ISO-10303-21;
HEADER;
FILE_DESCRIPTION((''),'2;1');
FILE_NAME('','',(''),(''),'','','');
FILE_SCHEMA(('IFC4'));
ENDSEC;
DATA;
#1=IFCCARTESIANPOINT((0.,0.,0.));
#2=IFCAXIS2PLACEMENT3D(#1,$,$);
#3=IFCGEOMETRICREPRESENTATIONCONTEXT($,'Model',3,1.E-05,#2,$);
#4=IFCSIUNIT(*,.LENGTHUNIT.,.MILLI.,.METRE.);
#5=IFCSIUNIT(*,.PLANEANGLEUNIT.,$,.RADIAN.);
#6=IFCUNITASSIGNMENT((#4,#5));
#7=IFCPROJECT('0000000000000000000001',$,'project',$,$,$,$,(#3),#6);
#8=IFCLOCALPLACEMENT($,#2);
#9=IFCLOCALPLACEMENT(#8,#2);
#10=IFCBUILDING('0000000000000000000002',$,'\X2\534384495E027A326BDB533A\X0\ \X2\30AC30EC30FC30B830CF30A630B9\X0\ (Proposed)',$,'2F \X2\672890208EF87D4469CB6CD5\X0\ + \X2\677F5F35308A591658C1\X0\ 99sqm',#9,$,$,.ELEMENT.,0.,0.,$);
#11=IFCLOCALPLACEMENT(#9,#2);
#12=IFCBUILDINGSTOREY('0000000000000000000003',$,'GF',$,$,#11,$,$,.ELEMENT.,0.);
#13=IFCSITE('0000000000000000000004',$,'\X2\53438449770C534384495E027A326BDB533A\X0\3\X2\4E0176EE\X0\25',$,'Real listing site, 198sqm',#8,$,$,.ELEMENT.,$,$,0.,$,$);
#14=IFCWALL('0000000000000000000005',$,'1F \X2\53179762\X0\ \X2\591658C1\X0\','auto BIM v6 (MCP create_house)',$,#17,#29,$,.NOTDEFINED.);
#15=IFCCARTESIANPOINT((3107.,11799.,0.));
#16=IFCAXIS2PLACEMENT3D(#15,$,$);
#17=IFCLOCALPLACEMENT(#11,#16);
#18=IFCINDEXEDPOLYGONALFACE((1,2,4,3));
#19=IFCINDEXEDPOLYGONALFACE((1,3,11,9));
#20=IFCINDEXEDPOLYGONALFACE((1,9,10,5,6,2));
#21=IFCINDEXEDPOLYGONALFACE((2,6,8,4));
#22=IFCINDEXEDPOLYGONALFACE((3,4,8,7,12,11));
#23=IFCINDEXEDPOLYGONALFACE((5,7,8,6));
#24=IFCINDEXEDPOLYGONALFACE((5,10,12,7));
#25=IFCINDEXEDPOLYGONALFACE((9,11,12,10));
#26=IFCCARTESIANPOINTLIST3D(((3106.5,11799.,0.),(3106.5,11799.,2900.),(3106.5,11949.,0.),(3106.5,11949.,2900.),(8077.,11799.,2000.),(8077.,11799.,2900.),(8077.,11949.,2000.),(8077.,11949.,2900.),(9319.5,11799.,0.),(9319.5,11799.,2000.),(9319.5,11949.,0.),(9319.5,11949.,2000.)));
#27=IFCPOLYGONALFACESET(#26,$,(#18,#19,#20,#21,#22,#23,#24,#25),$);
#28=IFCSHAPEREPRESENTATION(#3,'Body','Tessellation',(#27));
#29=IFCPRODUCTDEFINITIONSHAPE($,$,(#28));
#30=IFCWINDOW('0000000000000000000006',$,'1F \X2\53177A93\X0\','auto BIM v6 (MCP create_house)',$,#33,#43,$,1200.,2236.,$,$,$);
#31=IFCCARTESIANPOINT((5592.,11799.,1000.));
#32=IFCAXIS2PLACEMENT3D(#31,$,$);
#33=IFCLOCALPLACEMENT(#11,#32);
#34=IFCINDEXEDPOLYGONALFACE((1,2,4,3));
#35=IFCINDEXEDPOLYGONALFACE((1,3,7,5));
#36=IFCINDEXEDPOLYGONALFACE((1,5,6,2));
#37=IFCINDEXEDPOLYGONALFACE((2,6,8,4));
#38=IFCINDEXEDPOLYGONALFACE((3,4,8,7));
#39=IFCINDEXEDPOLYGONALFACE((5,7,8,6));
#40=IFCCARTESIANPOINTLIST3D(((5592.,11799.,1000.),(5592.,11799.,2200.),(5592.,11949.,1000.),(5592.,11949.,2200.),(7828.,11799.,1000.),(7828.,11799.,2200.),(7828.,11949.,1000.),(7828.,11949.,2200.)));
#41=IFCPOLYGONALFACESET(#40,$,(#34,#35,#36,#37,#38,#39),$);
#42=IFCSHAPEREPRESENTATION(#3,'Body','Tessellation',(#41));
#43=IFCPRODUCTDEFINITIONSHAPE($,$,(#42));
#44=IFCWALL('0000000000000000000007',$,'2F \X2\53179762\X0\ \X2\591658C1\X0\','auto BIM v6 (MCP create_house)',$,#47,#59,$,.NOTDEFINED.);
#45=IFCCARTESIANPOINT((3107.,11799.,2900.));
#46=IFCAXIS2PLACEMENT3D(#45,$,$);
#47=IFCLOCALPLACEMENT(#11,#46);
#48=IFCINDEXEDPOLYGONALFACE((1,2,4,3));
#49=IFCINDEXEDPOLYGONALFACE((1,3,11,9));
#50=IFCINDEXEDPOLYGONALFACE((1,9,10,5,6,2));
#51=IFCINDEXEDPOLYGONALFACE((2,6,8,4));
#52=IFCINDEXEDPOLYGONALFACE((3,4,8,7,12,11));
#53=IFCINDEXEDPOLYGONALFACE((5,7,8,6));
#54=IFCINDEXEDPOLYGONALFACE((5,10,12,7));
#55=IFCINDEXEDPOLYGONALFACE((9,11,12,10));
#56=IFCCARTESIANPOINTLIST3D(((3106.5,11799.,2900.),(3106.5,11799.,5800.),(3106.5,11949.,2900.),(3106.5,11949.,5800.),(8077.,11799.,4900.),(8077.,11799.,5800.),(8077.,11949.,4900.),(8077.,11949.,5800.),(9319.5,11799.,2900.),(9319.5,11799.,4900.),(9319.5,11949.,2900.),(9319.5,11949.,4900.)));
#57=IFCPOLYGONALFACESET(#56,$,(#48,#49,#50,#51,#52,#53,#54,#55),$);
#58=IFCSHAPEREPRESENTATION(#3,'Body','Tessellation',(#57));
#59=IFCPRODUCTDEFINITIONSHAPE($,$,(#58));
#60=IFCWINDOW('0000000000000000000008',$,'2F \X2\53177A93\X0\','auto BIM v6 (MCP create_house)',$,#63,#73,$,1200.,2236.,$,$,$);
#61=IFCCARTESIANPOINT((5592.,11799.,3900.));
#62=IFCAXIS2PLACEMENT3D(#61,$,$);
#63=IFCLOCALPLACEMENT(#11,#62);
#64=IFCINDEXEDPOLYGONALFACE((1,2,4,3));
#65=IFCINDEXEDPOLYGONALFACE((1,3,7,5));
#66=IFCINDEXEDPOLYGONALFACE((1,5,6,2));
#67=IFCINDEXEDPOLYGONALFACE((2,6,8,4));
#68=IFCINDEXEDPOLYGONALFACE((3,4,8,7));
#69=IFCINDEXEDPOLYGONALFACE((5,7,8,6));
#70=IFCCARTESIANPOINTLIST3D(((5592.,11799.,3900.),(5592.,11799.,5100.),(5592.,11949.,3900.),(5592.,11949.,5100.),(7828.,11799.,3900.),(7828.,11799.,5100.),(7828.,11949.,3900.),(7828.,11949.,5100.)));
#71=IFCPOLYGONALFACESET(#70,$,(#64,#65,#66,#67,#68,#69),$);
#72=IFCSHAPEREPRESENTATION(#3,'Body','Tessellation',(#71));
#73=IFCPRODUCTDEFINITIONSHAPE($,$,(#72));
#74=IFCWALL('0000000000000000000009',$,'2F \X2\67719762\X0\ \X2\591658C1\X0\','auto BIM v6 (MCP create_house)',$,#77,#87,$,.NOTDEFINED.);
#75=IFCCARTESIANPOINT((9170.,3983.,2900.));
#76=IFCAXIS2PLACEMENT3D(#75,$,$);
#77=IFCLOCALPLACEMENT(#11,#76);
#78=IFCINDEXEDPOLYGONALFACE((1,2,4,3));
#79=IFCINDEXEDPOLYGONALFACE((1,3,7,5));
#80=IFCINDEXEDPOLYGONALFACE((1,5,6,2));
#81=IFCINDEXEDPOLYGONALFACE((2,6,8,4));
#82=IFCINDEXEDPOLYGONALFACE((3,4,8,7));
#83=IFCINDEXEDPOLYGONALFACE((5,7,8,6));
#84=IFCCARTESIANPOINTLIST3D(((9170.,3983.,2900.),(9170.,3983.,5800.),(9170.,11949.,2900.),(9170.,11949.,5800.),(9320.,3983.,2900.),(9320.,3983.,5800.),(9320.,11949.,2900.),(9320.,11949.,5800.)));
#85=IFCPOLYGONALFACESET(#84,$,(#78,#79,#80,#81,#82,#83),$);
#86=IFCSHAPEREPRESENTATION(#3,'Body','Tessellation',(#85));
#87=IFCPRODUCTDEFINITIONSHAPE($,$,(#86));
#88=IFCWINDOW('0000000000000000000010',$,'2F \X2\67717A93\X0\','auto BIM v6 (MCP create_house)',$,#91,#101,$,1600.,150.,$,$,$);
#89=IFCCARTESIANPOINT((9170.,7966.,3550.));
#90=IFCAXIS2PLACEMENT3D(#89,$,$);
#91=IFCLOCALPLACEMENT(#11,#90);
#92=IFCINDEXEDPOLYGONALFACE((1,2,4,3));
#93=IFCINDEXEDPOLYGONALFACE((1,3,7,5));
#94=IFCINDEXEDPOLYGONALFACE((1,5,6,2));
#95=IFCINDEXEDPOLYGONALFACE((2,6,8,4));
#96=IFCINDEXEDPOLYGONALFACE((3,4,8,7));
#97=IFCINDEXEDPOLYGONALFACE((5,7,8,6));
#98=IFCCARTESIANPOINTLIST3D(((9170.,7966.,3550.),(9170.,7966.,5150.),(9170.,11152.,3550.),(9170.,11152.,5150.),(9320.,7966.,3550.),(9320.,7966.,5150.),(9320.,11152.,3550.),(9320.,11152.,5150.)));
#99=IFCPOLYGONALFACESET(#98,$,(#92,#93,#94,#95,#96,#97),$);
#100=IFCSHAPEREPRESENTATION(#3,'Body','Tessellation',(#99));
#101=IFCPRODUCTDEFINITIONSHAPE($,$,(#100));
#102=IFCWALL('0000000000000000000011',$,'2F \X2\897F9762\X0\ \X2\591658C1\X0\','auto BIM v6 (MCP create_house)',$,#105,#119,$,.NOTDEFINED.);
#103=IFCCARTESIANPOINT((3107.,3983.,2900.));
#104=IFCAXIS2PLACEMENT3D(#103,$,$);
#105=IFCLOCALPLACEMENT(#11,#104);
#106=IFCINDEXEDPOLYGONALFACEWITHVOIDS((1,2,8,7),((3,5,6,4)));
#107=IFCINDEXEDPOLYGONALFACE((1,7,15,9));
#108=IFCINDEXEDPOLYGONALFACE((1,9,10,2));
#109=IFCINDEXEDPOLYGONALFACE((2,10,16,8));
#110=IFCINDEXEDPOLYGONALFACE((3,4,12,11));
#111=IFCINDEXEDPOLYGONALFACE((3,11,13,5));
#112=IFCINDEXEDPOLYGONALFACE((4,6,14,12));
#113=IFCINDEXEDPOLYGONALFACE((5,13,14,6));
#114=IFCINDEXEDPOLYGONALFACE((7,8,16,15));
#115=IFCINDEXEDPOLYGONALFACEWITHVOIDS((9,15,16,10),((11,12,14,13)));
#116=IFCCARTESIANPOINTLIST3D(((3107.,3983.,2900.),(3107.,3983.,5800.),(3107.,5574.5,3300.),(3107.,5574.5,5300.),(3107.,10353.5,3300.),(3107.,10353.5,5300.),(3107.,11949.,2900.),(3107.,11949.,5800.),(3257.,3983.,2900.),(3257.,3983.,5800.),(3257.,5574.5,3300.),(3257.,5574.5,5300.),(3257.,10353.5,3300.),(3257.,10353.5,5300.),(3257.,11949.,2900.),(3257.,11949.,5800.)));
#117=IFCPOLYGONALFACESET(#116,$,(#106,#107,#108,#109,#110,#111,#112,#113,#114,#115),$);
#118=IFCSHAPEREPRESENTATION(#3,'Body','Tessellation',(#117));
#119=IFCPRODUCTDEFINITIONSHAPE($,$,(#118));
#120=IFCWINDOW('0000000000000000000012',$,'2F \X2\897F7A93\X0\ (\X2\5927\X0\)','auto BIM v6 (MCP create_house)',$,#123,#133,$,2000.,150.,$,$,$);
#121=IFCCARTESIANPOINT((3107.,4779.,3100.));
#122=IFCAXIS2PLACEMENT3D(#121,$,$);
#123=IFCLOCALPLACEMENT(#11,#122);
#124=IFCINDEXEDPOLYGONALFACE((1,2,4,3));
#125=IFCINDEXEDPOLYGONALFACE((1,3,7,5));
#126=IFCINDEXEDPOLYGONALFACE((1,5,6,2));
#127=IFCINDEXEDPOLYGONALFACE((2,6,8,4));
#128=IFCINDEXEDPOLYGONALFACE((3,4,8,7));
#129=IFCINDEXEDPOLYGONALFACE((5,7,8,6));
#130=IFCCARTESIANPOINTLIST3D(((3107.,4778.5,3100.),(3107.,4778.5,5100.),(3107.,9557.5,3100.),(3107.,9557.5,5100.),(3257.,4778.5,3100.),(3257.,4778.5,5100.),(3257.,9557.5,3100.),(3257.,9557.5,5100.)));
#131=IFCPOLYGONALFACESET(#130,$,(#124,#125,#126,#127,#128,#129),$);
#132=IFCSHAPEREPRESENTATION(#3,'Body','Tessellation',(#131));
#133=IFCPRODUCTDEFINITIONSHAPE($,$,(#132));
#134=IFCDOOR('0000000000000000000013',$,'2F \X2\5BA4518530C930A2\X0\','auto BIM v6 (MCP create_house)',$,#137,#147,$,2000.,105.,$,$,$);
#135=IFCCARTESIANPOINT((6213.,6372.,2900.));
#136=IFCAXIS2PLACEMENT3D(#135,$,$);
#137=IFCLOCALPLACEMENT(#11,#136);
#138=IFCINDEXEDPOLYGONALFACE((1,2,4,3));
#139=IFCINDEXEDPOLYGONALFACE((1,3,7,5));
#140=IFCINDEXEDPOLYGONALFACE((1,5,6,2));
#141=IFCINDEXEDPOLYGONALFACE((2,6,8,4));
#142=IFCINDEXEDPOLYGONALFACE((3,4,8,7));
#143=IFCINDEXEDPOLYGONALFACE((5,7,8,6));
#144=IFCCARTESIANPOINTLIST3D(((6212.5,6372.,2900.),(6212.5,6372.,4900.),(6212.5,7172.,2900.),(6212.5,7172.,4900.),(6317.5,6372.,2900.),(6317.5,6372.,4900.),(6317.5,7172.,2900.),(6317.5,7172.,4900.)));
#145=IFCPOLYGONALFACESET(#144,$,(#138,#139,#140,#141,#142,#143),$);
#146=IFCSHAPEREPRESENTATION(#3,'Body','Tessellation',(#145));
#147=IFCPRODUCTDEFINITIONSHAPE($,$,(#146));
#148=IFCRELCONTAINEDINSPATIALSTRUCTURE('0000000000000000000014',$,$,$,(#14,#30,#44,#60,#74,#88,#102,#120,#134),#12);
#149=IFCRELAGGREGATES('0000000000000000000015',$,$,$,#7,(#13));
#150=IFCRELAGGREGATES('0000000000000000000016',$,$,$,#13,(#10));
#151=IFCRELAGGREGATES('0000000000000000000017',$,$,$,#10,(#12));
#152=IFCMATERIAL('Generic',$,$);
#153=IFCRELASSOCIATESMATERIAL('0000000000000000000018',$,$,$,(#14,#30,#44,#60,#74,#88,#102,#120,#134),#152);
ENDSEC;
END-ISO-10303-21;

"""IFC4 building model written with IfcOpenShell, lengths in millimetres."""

from ifc_helpers import new_model, si_unit, frame, frame_2d, origin, place, context, project, spatial, rectangle, extrude, material, element, fill, save


model = new_model("IFC4")

# Units and contexts
model_context = context("Model", 3, precision=1e-05, world=origin())
ifc_project = project(units=[si_unit("LENGTHUNIT", "METRE", prefix="MILLI"), si_unit("PLANEANGLEUNIT", "RADIAN")], contexts=[model_context])

# Site, building, storey
site_placement = place(None, origin())
site = spatial("IfcSite", under=ifc_project, at=site_placement, Name="千葉県千葉市稲毛区3丁目25", ObjectType="Real listing site, 198sqm", CompositionType="ELEMENT", RefElevation=0.0)
building_placement = place(site_placement, origin())
building = spatial("IfcBuilding", under=site, at=building_placement, Name="千葉市稲毛区 ガレージハウス (Proposed)", ObjectType="2F 木造軸組構法 + 板張り外壁 99sqm", CompositionType="ELEMENT", ElevationOfRefHeight=0.0, ElevationOfTerrain=0.0)
storey_placement = place(building_placement, origin())
storey = spatial("IfcBuildingStorey", under=building, at=storey_placement, Name="GF", CompositionType="ELEMENT", Elevation=0.0)

# Wall, opening, window
ifc_material = material(Name="Generic")
wall_1_placement = place(storey_placement, frame((3107.0, 11799.0, 0.0)))
wall_1 = element("IfcWall", 1, at=wall_1_placement, inside=storey, material=ifc_material, Name="1F 北面 外壁", Description="auto BIM v6 (MCP create_house)", PredefinedType="NOTDEFINED", context=model_context, shape_type="SweptSolid", body=[
    extrude(rectangle(XDim=6213.0, YDim=150.0, at=frame_2d((3106.0, 75.0))), frame((3107.0, 11799.0, 0.0)), (0.0, 0.0, 1.0), 2900.0),
])
opening_1_placement = place(storey_placement, frame((5592.0, 11799.0, 1000.0)))
opening_1 = element("IfcOpeningElement", 2, at=opening_1_placement, cuts=wall_1, PredefinedType="NOTDEFINED", context=model_context, shape_type="SweptSolid", body=[
    extrude(rectangle(XDim=2236.0, YDim=150.0, at=frame_2d((1118.0, 75.0))), frame((5592.0, 11799.0, 1000.0)), (0.0, 0.0, 1.0), 1200.0),
])
window_1_placement = place(storey_placement, frame((5592.0, 11799.0, 1000.0)))
window_1 = element("IfcWindow", 3, at=window_1_placement, inside=storey, material=ifc_material, Name="1F 北窓", Description="auto BIM v6 (MCP create_house)", OverallHeight=1200.0, OverallWidth=2236.0, context=model_context, shape_type="SweptSolid", body=[
    extrude(rectangle(XDim=2236.0, YDim=150.0, at=frame_2d((1118.0, 75.0))), frame((5592.0, 11799.0, 1000.0)), (0.0, 0.0, 1.0), 1200.0),
])
fill(opening_1, window_1)

# Walls, openings, windows
wall_2_placement = place(storey_placement, frame((3107.0, 11799.0, 2900.0)))
wall_2 = element("IfcWall", 4, at=wall_2_placement, inside=storey, material=ifc_material, Name="2F 北面 外壁", Description="auto BIM v6 (MCP create_house)", PredefinedType="NOTDEFINED", context=model_context, shape_type="SweptSolid", body=[
    extrude(rectangle(XDim=6213.0, YDim=150.0, at=frame_2d((3106.0, 75.0))), frame((3107.0, 11799.0, 2900.0)), (0.0, 0.0, 1.0), 2900.0),
])
opening_2_placement = place(storey_placement, frame((5592.0, 11799.0, 3900.0)))
opening_2 = element("IfcOpeningElement", 5, at=opening_2_placement, cuts=wall_2, PredefinedType="NOTDEFINED", context=model_context, shape_type="SweptSolid", body=[
    extrude(rectangle(XDim=2236.0, YDim=150.0, at=frame_2d((1118.0, 75.0))), frame((5592.0, 11799.0, 3900.0)), (0.0, 0.0, 1.0), 1200.0),
])
window_2_placement = place(storey_placement, frame((5592.0, 11799.0, 3900.0)))
window_2 = element("IfcWindow", 6, at=window_2_placement, inside=storey, material=ifc_material, Name="2F 北窓", Description="auto BIM v6 (MCP create_house)", OverallHeight=1200.0, OverallWidth=2236.0, context=model_context, shape_type="SweptSolid", body=[
    extrude(rectangle(XDim=2236.0, YDim=150.0, at=frame_2d((1118.0, 75.0))), frame((5592.0, 11799.0, 3900.0)), (0.0, 0.0, 1.0), 1200.0),
])
fill(opening_2, window_2)
wall_3_placement = place(storey_placement, frame((9170.0, 3983.0, 2900.0)))
wall_3 = element("IfcWall", 7, at=wall_3_placement, inside=storey, material=ifc_material, Name="2F 東面 外壁", Description="auto BIM v6 (MCP create_house)", PredefinedType="NOTDEFINED", context=model_context, shape_type="SweptSolid", body=[
    extrude(rectangle(XDim=150.0, YDim=7966.0, at=frame_2d((75.0, 3983.0))), frame((9170.0, 3983.0, 2900.0)), (0.0, 0.0, 1.0), 2900.0),
])
opening_3_placement = place(storey_placement, frame((9170.0, 7966.0, 3550.0)))
opening_3 = element("IfcOpeningElement", 8, at=opening_3_placement, cuts=wall_3, PredefinedType="NOTDEFINED", context=model_context, shape_type="SweptSolid", body=[
    extrude(rectangle(XDim=150.0, YDim=3186.0, at=frame_2d((75.0, 1593.0))), frame((9170.0, 7966.0, 3550.0)), (0.0, 0.0, 1.0), 1600.0),
])
window_3_placement = place(storey_placement, frame((9170.0, 7966.0, 3550.0)))
window_3 = element("IfcWindow", 9, at=window_3_placement, inside=storey, material=ifc_material, Name="2F 東窓", Description="auto BIM v6 (MCP create_house)", OverallHeight=1600.0, OverallWidth=150.0, context=model_context, shape_type="SweptSolid", body=[
    extrude(rectangle(XDim=150.0, YDim=3186.0, at=frame_2d((75.0, 1593.0))), frame((9170.0, 7966.0, 3550.0)), (0.0, 0.0, 1.0), 1600.0),
])
fill(opening_3, window_3)
wall_4_placement = place(storey_placement, frame((3107.0, 3983.0, 2900.0)))
wall_4 = element("IfcWall", 10, at=wall_4_placement, inside=storey, material=ifc_material, Name="2F 西面 外壁", Description="auto BIM v6 (MCP create_house)", PredefinedType="NOTDEFINED", context=model_context, shape_type="SweptSolid", body=[
    extrude(rectangle(XDim=150.0, YDim=7966.0, at=frame_2d((75.0, 3983.0))), frame((3107.0, 3983.0, 2900.0)), (0.0, 0.0, 1.0), 2900.0),
])
opening_4_placement = place(storey_placement, frame((3107.0, 4779.0, 3100.0)))
opening_4 = element("IfcOpeningElement", 11, at=opening_4_placement, cuts=wall_4, PredefinedType="NOTDEFINED", context=model_context, shape_type="SweptSolid", body=[
    extrude(rectangle(XDim=150.0, YDim=4779.0, at=frame_2d((75.0, 2389.0))), frame((3107.0, 4779.0, 3100.0)), (0.0, 0.0, 1.0), 2000.0),
])
window_4_placement = place(storey_placement, frame((3107.0, 4779.0, 3100.0)))
window_4 = element("IfcWindow", 12, at=window_4_placement, inside=storey, material=ifc_material, Name="2F 西窓 (大)", Description="auto BIM v6 (MCP create_house)", OverallHeight=2000.0, OverallWidth=150.0, context=model_context, shape_type="SweptSolid", body=[
    extrude(rectangle(XDim=150.0, YDim=4779.0, at=frame_2d((75.0, 2389.0))), frame((3107.0, 4779.0, 3100.0)), (0.0, 0.0, 1.0), 2000.0),
])
fill(opening_4, window_4)

# Door
door_placement = place(storey_placement, frame((6213.0, 6372.0, 2900.0)))
element("IfcDoor", 13, at=door_placement, inside=storey, material=ifc_material, Name="2F 室内ドア", Description="auto BIM v6 (MCP create_house)", OverallHeight=2000.0, OverallWidth=105.0, context=model_context, shape_type="SweptSolid", body=[
    extrude(rectangle(XDim=105.0, YDim=800.0, at=frame_2d((52.0, 400.0))), frame((6213.0, 6372.0, 2900.0)), (0.0, 0.0, 1.0), 2000.0),
])

save(model, "model.ifc")
